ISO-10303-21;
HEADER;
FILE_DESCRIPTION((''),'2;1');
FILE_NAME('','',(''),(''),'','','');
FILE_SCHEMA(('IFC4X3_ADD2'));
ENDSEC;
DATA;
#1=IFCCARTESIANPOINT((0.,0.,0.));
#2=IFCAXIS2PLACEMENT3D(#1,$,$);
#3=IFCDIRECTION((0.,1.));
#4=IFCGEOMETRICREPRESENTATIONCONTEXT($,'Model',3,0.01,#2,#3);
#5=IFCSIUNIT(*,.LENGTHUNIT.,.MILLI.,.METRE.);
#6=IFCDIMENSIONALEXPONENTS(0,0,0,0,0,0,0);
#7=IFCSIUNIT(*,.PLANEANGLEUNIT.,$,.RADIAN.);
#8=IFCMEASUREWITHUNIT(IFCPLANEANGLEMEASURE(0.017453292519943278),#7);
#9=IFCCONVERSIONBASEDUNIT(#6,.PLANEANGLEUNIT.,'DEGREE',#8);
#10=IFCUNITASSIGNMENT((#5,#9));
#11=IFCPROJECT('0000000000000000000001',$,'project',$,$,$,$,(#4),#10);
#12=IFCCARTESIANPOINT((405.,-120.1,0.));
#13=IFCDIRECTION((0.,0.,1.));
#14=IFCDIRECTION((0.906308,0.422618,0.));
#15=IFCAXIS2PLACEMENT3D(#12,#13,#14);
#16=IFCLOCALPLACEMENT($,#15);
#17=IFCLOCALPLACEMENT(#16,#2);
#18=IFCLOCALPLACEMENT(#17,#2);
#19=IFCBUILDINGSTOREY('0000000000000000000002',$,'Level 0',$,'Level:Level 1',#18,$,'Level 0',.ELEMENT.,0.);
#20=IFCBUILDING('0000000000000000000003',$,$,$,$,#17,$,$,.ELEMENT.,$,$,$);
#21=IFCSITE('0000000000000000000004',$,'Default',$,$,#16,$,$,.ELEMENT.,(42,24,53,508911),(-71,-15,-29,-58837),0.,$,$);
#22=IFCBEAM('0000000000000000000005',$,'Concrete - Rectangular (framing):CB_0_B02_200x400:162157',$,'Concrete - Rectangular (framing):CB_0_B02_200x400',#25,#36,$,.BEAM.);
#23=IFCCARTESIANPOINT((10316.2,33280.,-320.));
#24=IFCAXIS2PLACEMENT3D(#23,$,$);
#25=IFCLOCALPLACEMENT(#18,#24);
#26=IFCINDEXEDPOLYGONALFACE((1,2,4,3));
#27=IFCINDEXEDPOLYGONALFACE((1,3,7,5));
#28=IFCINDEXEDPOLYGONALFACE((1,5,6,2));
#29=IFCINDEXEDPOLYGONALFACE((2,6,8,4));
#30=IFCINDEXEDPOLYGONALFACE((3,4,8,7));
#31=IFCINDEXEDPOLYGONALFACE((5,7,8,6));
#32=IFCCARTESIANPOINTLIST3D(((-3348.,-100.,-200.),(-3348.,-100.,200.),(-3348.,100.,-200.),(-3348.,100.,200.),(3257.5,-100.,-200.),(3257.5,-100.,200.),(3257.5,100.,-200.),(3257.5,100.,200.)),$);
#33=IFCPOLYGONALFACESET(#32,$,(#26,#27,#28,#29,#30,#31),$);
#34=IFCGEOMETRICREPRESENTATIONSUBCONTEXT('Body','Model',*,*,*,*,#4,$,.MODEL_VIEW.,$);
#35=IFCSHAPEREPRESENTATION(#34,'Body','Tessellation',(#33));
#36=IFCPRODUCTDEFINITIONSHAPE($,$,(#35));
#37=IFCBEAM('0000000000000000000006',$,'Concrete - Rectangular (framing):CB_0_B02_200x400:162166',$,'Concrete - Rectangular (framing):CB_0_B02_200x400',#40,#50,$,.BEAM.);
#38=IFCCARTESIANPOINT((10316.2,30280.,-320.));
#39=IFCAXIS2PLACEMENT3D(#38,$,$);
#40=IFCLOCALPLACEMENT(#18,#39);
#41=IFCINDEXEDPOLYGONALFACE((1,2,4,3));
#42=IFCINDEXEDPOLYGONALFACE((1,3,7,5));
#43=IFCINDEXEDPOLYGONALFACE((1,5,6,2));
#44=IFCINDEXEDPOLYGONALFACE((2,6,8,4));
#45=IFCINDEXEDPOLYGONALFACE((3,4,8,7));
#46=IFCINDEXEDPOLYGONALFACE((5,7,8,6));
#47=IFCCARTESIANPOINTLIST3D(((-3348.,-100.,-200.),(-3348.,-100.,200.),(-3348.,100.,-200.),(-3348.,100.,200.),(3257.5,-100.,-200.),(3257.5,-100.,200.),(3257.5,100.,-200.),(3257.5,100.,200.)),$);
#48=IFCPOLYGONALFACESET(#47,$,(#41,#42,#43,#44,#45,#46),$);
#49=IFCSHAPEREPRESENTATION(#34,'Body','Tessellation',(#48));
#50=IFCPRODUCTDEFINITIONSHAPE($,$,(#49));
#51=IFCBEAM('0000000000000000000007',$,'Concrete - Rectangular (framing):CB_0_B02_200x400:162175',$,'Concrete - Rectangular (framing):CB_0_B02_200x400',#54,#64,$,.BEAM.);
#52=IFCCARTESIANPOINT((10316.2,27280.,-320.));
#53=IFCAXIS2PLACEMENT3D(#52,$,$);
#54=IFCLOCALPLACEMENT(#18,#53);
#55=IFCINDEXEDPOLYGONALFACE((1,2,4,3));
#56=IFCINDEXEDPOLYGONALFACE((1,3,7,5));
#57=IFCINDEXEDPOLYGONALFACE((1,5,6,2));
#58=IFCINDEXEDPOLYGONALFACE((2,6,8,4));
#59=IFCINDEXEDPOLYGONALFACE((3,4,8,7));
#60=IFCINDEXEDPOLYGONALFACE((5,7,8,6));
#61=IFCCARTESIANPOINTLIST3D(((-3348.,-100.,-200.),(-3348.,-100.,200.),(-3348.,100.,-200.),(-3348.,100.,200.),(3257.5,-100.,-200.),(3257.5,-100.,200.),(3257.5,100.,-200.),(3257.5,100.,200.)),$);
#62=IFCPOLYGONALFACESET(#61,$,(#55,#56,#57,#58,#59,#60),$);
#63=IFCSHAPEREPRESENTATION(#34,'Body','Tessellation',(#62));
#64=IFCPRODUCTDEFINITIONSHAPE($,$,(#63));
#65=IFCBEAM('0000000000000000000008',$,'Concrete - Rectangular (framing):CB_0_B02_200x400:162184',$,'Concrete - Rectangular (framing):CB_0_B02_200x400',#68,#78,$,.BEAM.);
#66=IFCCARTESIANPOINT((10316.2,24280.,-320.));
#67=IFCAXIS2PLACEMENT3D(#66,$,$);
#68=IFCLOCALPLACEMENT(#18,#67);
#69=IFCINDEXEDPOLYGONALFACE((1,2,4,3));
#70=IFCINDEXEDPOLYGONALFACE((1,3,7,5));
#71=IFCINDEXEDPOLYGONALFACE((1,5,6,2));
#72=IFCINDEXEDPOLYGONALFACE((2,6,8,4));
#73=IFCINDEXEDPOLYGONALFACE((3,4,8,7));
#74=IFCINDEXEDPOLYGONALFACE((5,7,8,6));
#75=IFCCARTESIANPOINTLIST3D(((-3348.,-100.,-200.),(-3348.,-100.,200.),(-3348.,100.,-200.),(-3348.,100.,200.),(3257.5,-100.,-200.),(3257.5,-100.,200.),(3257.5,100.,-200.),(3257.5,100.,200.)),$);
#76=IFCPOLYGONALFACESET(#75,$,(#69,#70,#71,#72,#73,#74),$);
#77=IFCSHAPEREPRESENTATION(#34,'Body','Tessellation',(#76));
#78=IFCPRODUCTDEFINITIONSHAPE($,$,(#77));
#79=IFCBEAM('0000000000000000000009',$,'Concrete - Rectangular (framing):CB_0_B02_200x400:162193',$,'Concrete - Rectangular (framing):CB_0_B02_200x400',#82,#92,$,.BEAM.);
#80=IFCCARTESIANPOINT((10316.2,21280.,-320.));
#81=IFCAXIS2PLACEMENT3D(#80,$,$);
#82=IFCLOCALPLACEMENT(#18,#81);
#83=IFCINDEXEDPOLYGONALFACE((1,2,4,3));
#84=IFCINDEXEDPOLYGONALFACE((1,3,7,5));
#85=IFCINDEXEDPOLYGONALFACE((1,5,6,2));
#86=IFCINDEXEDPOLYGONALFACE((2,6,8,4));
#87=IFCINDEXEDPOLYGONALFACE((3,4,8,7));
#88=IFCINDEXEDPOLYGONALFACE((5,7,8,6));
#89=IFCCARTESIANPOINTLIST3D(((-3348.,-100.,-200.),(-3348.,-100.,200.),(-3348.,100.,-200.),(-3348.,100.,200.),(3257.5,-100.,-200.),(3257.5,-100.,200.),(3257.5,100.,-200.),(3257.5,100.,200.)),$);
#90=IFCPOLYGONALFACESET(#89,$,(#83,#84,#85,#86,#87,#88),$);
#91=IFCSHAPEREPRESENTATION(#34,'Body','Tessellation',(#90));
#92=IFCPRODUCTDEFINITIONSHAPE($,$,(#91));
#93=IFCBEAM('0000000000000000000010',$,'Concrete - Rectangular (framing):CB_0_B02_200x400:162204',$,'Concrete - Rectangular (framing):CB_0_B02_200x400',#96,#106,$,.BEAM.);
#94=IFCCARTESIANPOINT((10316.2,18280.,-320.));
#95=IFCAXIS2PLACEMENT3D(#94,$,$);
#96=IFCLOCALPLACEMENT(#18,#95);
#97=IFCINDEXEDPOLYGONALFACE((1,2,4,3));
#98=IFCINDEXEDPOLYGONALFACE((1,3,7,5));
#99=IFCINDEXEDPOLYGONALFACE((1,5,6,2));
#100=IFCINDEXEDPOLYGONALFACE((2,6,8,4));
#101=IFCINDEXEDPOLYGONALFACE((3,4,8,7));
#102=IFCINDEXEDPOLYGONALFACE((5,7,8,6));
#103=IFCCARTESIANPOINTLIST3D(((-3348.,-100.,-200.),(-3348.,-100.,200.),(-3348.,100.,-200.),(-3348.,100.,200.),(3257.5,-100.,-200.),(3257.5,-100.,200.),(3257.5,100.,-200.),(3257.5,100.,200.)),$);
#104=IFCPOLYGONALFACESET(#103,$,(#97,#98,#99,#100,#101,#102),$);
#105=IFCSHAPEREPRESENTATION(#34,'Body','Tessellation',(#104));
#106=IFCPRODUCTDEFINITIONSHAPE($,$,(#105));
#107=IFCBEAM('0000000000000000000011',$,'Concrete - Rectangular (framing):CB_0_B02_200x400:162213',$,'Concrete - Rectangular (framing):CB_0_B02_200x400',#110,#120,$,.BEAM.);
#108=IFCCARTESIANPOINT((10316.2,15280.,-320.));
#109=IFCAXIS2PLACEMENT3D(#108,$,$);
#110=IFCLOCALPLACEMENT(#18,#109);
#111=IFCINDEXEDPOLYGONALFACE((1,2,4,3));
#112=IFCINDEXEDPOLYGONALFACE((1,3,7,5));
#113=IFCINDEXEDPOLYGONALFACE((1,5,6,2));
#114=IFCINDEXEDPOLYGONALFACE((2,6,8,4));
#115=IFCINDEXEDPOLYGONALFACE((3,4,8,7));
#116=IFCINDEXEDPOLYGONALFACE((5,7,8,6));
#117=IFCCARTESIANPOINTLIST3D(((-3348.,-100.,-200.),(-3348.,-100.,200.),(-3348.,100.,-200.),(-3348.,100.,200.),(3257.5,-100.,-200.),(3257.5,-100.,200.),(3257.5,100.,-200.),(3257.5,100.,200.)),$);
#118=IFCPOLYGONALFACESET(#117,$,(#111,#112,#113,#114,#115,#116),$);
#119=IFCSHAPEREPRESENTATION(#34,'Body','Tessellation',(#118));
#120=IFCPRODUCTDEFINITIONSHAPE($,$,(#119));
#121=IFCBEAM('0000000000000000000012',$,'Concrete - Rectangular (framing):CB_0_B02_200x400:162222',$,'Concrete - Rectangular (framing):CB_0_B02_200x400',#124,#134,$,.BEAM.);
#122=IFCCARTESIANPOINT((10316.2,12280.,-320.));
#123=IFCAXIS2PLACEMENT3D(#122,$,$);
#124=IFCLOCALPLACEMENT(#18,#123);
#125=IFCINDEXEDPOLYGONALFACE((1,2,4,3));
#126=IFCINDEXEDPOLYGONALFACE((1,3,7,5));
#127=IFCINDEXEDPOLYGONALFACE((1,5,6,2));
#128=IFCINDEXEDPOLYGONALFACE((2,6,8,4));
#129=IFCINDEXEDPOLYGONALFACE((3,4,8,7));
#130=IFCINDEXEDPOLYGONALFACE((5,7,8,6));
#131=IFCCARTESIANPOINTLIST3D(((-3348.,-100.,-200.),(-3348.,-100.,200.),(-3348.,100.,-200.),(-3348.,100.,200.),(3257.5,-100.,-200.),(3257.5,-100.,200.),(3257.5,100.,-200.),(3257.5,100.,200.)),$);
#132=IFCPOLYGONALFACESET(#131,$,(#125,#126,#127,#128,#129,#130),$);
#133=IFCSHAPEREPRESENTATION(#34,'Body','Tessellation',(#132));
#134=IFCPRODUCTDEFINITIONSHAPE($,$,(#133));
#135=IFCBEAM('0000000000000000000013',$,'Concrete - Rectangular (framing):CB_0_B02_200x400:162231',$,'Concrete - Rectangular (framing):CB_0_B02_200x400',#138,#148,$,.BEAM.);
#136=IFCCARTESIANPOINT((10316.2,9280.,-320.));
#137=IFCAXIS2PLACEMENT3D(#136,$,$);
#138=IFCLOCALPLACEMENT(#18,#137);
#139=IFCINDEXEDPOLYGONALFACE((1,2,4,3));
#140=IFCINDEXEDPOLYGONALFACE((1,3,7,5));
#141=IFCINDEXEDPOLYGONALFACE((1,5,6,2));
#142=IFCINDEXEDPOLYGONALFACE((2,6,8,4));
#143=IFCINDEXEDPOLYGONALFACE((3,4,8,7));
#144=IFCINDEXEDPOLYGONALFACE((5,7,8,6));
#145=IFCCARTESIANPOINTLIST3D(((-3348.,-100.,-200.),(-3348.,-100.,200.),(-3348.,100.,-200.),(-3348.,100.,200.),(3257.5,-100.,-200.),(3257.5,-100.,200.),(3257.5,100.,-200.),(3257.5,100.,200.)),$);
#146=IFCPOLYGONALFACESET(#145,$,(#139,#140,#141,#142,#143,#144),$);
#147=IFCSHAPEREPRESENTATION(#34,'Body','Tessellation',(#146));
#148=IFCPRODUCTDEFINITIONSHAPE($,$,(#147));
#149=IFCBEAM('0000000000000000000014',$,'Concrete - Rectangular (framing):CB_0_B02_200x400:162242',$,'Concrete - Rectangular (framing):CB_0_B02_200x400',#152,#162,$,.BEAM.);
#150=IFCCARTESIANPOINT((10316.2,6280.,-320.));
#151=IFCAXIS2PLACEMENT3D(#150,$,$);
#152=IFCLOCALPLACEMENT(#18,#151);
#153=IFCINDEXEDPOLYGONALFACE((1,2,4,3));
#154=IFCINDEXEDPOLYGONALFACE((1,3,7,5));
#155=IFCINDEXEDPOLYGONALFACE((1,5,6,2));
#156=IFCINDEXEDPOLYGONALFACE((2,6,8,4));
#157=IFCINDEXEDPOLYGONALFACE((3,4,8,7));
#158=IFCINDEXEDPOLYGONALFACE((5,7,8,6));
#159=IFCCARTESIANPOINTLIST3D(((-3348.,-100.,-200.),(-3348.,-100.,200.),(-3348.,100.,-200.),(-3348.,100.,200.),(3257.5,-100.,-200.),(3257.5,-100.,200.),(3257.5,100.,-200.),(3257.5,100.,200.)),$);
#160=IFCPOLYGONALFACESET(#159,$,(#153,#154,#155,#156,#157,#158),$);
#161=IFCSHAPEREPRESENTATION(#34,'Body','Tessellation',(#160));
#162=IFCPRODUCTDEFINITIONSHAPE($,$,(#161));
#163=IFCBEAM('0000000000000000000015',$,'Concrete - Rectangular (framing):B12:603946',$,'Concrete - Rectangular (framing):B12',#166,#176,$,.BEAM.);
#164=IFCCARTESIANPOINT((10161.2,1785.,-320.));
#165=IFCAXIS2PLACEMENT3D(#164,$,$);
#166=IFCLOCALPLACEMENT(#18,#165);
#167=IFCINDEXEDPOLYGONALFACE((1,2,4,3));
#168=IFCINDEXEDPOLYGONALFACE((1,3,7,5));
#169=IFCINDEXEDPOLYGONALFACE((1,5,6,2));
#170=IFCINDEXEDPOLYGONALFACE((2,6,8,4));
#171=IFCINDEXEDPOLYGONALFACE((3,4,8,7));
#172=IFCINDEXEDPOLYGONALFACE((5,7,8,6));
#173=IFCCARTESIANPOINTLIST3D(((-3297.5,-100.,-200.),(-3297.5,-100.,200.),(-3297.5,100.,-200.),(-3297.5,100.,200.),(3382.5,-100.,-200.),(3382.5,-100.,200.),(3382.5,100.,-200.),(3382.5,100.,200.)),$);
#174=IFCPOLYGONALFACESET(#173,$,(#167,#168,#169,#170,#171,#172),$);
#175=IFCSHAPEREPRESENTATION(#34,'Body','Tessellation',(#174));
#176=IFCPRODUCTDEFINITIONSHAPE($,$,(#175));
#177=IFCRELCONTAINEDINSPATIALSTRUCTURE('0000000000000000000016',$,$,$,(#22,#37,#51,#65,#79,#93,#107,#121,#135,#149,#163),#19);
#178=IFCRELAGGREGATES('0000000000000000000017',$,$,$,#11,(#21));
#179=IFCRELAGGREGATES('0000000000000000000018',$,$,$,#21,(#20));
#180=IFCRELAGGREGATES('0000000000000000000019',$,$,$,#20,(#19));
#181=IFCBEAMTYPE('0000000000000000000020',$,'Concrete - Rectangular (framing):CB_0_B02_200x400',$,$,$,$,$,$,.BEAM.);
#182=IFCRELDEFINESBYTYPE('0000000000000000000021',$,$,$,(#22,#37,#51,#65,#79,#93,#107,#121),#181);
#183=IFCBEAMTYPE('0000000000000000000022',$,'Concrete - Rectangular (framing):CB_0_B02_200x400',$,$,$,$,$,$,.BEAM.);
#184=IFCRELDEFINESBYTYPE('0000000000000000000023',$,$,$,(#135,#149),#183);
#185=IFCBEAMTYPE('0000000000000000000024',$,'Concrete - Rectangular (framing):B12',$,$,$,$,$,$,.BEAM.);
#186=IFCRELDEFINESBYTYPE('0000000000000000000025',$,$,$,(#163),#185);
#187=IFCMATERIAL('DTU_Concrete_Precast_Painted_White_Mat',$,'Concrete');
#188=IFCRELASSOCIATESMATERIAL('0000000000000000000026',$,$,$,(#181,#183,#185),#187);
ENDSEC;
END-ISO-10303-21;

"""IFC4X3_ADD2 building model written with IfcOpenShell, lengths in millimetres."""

from ifc_helpers import new_model, entity, si_unit, converted_unit, direction, frame, frame_2d, origin, origin_2d_with_axis, place, context, subcontext, project, spatial, rectangle, extrude, source, transform, mapped, material, material_profile, profile_set, type_object, type_shapes, element, save


model = new_model("IFC4X3_ADD2")

# Units and contexts
model_context = context("Model", 3, precision=0.01, world=origin(), true_north=direction((0.0, 1.0)))
body_context = subcontext(model_context, "Body", "Model", "MODEL_VIEW")
ifc_project = project(units=[si_unit("LENGTHUNIT", "METRE", prefix="MILLI"), converted_unit("PLANEANGLEUNIT", "DEGREE", entity("IfcPlaneAngleMeasure", 0.017453292519943278), si_unit("PLANEANGLEUNIT", "RADIAN"), dimensions=[0, 0, 0, 0, 0, 0, 0])], contexts=[model_context])

# Site, building, storey
site_placement = place(None, frame((405.0, -120.1, 0.0), z_axis=(0.0, 0.0, 1.0), x_axis=(0.906308, 0.422618, 0.0)))
site = spatial("IfcSite", under=ifc_project, at=site_placement, Name="Default", CompositionType="ELEMENT", RefLatitude=(42, 24, 53, 508911), RefLongitude=(-71, -15, -29, -58837), RefElevation=0.0)
building_placement = place(site_placement, origin())
building = spatial("IfcBuilding", under=site, at=building_placement, CompositionType="ELEMENT")
storey_placement = place(building_placement, origin())
storey = spatial("IfcBuildingStorey", under=building, at=storey_placement, Name="Level 0", ObjectType="Level:Level 1", LongName="Level 0", CompositionType="ELEMENT", Elevation=0.0)

# Beams
ifc_material_1 = material(Name="DTU_Concrete_Precast_Painted_White_Mat", Category="Concrete")
ifc_material_profile_1 = material_profile(ifc_material_1, rectangle(XDim=7035.5, YDim=200.0, at=frame_2d((0.0, 0.0), x_axis=(1.0, 0.0))), Name="CB_0_B02_200x400")
ifc_profile_set_1 = profile_set([ifc_material_profile_1], Name="CB_0_B02_200x400")
beam_type_1 = type_object("IfcBeamType", Name="Concrete - Rectangular (framing):CB_0_B02_200x400", PredefinedType="BEAM", material=ifc_profile_set_1)
shared_shape_1 = source(origin(), body_context, "Body", "SweptSolid", [
    extrude(rectangle(XDim=6605.5, YDim=200.0, at=origin_2d_with_axis()), frame((-45.2, 0.0, -200.0), z_axis=(0.0, 0.0, 1.0), x_axis=(-1.0, 0.0, 0.0)), (0.0, 0.0, 1.0), 400.0),
])
type_shapes(beam_type_1, [shared_shape_1])
for number, where, name in (
    (1, (10316.2, 33280.0, -320.0), "Concrete - Rectangular (framing):CB_0_B02_200x400:162157"),
    (2, (10316.2, 30280.0, -320.0), "Concrete - Rectangular (framing):CB_0_B02_200x400:162166"),
    (3, (10316.2, 27280.0, -320.0), "Concrete - Rectangular (framing):CB_0_B02_200x400:162175"),
    (4, (10316.2, 24280.0, -320.0), "Concrete - Rectangular (framing):CB_0_B02_200x400:162184"),
    (5, (10316.2, 21280.0, -320.0), "Concrete - Rectangular (framing):CB_0_B02_200x400:162193"),
    (6, (10316.2, 18280.0, -320.0), "Concrete - Rectangular (framing):CB_0_B02_200x400:162204"),
    (7, (10316.2, 15280.0, -320.0), "Concrete - Rectangular (framing):CB_0_B02_200x400:162213"),
    (8, (10316.2, 12280.0, -320.0), "Concrete - Rectangular (framing):CB_0_B02_200x400:162222"),
):
    element("IfcBeam", number, at=place(storey_placement, frame(where)), inside=storey, type_object=beam_type_1, Name=name, ObjectType="Concrete - Rectangular (framing):CB_0_B02_200x400", PredefinedType="BEAM", context=body_context, shape_type="MappedRepresentation", body=[
        mapped(shared_shape_1, transform((0.0, 0.0, 0.0), scale=1.0)),
    ])
beam_type_2 = type_object("IfcBeamType", Name="Concrete - Rectangular (framing):CB_0_B02_200x400", PredefinedType="BEAM", material=ifc_profile_set_1)
shared_shape_2 = source(origin(), body_context, "Body", "SweptSolid", [
    extrude(rectangle(XDim=6605.5, YDim=200.0, at=origin_2d_with_axis()), frame((-45.3, 0.0, -200.0), z_axis=(0.0, 0.0, 1.0), x_axis=(-1.0, 0.0, 0.0)), (0.0, 0.0, 1.0), 400.0),
])
type_shapes(beam_type_2, [shared_shape_2])
for number, where, name in (
    (9, (10316.2, 9280.0, -320.0), "Concrete - Rectangular (framing):CB_0_B02_200x400:162231"),
    (10, (10316.2, 6280.0, -320.0), "Concrete - Rectangular (framing):CB_0_B02_200x400:162242"),
):
    element("IfcBeam", number, at=place(storey_placement, frame(where)), inside=storey, type_object=beam_type_2, Name=name, ObjectType="Concrete - Rectangular (framing):CB_0_B02_200x400", PredefinedType="BEAM", context=body_context, shape_type="MappedRepresentation", body=[
        mapped(shared_shape_2, transform((0.0, 0.0, 0.0), scale=1.0)),
    ])
ifc_material_profile_2 = material_profile(ifc_material_1, rectangle(XDim=6700.0, YDim=200.0, at=origin_2d_with_axis()), Name="B12")
ifc_profile_set_2 = profile_set([ifc_material_profile_2], Name="B12")
beam_type_3 = type_object("IfcBeamType", Name="Concrete - Rectangular (framing):B12", PredefinedType="BEAM", material=ifc_profile_set_2)
shared_shape_3 = source(origin(), body_context, "Body", "SweptSolid", [
    extrude(rectangle(XDim=6680.0, YDim=200.0, at=origin_2d_with_axis()), frame((42.5, 0.0, -200.0), z_axis=(0.0, 0.0, 1.0), x_axis=(-1.0, 0.0, 0.0)), (0.0, 0.0, 1.0), 400.0),
])
type_shapes(beam_type_3, [shared_shape_3])
beam_placement = place(storey_placement, frame((10161.2, 1785.0, -320.0)))
element("IfcBeam", 11, at=beam_placement, inside=storey, type_object=beam_type_3, Name="Concrete - Rectangular (framing):B12:603946", ObjectType="Concrete - Rectangular (framing):B12", PredefinedType="BEAM", context=body_context, shape_type="MappedRepresentation", body=[
    mapped(shared_shape_3, transform((0.0, 0.0, 0.0), scale=1.0)),
])

save(model, "model.ifc")
